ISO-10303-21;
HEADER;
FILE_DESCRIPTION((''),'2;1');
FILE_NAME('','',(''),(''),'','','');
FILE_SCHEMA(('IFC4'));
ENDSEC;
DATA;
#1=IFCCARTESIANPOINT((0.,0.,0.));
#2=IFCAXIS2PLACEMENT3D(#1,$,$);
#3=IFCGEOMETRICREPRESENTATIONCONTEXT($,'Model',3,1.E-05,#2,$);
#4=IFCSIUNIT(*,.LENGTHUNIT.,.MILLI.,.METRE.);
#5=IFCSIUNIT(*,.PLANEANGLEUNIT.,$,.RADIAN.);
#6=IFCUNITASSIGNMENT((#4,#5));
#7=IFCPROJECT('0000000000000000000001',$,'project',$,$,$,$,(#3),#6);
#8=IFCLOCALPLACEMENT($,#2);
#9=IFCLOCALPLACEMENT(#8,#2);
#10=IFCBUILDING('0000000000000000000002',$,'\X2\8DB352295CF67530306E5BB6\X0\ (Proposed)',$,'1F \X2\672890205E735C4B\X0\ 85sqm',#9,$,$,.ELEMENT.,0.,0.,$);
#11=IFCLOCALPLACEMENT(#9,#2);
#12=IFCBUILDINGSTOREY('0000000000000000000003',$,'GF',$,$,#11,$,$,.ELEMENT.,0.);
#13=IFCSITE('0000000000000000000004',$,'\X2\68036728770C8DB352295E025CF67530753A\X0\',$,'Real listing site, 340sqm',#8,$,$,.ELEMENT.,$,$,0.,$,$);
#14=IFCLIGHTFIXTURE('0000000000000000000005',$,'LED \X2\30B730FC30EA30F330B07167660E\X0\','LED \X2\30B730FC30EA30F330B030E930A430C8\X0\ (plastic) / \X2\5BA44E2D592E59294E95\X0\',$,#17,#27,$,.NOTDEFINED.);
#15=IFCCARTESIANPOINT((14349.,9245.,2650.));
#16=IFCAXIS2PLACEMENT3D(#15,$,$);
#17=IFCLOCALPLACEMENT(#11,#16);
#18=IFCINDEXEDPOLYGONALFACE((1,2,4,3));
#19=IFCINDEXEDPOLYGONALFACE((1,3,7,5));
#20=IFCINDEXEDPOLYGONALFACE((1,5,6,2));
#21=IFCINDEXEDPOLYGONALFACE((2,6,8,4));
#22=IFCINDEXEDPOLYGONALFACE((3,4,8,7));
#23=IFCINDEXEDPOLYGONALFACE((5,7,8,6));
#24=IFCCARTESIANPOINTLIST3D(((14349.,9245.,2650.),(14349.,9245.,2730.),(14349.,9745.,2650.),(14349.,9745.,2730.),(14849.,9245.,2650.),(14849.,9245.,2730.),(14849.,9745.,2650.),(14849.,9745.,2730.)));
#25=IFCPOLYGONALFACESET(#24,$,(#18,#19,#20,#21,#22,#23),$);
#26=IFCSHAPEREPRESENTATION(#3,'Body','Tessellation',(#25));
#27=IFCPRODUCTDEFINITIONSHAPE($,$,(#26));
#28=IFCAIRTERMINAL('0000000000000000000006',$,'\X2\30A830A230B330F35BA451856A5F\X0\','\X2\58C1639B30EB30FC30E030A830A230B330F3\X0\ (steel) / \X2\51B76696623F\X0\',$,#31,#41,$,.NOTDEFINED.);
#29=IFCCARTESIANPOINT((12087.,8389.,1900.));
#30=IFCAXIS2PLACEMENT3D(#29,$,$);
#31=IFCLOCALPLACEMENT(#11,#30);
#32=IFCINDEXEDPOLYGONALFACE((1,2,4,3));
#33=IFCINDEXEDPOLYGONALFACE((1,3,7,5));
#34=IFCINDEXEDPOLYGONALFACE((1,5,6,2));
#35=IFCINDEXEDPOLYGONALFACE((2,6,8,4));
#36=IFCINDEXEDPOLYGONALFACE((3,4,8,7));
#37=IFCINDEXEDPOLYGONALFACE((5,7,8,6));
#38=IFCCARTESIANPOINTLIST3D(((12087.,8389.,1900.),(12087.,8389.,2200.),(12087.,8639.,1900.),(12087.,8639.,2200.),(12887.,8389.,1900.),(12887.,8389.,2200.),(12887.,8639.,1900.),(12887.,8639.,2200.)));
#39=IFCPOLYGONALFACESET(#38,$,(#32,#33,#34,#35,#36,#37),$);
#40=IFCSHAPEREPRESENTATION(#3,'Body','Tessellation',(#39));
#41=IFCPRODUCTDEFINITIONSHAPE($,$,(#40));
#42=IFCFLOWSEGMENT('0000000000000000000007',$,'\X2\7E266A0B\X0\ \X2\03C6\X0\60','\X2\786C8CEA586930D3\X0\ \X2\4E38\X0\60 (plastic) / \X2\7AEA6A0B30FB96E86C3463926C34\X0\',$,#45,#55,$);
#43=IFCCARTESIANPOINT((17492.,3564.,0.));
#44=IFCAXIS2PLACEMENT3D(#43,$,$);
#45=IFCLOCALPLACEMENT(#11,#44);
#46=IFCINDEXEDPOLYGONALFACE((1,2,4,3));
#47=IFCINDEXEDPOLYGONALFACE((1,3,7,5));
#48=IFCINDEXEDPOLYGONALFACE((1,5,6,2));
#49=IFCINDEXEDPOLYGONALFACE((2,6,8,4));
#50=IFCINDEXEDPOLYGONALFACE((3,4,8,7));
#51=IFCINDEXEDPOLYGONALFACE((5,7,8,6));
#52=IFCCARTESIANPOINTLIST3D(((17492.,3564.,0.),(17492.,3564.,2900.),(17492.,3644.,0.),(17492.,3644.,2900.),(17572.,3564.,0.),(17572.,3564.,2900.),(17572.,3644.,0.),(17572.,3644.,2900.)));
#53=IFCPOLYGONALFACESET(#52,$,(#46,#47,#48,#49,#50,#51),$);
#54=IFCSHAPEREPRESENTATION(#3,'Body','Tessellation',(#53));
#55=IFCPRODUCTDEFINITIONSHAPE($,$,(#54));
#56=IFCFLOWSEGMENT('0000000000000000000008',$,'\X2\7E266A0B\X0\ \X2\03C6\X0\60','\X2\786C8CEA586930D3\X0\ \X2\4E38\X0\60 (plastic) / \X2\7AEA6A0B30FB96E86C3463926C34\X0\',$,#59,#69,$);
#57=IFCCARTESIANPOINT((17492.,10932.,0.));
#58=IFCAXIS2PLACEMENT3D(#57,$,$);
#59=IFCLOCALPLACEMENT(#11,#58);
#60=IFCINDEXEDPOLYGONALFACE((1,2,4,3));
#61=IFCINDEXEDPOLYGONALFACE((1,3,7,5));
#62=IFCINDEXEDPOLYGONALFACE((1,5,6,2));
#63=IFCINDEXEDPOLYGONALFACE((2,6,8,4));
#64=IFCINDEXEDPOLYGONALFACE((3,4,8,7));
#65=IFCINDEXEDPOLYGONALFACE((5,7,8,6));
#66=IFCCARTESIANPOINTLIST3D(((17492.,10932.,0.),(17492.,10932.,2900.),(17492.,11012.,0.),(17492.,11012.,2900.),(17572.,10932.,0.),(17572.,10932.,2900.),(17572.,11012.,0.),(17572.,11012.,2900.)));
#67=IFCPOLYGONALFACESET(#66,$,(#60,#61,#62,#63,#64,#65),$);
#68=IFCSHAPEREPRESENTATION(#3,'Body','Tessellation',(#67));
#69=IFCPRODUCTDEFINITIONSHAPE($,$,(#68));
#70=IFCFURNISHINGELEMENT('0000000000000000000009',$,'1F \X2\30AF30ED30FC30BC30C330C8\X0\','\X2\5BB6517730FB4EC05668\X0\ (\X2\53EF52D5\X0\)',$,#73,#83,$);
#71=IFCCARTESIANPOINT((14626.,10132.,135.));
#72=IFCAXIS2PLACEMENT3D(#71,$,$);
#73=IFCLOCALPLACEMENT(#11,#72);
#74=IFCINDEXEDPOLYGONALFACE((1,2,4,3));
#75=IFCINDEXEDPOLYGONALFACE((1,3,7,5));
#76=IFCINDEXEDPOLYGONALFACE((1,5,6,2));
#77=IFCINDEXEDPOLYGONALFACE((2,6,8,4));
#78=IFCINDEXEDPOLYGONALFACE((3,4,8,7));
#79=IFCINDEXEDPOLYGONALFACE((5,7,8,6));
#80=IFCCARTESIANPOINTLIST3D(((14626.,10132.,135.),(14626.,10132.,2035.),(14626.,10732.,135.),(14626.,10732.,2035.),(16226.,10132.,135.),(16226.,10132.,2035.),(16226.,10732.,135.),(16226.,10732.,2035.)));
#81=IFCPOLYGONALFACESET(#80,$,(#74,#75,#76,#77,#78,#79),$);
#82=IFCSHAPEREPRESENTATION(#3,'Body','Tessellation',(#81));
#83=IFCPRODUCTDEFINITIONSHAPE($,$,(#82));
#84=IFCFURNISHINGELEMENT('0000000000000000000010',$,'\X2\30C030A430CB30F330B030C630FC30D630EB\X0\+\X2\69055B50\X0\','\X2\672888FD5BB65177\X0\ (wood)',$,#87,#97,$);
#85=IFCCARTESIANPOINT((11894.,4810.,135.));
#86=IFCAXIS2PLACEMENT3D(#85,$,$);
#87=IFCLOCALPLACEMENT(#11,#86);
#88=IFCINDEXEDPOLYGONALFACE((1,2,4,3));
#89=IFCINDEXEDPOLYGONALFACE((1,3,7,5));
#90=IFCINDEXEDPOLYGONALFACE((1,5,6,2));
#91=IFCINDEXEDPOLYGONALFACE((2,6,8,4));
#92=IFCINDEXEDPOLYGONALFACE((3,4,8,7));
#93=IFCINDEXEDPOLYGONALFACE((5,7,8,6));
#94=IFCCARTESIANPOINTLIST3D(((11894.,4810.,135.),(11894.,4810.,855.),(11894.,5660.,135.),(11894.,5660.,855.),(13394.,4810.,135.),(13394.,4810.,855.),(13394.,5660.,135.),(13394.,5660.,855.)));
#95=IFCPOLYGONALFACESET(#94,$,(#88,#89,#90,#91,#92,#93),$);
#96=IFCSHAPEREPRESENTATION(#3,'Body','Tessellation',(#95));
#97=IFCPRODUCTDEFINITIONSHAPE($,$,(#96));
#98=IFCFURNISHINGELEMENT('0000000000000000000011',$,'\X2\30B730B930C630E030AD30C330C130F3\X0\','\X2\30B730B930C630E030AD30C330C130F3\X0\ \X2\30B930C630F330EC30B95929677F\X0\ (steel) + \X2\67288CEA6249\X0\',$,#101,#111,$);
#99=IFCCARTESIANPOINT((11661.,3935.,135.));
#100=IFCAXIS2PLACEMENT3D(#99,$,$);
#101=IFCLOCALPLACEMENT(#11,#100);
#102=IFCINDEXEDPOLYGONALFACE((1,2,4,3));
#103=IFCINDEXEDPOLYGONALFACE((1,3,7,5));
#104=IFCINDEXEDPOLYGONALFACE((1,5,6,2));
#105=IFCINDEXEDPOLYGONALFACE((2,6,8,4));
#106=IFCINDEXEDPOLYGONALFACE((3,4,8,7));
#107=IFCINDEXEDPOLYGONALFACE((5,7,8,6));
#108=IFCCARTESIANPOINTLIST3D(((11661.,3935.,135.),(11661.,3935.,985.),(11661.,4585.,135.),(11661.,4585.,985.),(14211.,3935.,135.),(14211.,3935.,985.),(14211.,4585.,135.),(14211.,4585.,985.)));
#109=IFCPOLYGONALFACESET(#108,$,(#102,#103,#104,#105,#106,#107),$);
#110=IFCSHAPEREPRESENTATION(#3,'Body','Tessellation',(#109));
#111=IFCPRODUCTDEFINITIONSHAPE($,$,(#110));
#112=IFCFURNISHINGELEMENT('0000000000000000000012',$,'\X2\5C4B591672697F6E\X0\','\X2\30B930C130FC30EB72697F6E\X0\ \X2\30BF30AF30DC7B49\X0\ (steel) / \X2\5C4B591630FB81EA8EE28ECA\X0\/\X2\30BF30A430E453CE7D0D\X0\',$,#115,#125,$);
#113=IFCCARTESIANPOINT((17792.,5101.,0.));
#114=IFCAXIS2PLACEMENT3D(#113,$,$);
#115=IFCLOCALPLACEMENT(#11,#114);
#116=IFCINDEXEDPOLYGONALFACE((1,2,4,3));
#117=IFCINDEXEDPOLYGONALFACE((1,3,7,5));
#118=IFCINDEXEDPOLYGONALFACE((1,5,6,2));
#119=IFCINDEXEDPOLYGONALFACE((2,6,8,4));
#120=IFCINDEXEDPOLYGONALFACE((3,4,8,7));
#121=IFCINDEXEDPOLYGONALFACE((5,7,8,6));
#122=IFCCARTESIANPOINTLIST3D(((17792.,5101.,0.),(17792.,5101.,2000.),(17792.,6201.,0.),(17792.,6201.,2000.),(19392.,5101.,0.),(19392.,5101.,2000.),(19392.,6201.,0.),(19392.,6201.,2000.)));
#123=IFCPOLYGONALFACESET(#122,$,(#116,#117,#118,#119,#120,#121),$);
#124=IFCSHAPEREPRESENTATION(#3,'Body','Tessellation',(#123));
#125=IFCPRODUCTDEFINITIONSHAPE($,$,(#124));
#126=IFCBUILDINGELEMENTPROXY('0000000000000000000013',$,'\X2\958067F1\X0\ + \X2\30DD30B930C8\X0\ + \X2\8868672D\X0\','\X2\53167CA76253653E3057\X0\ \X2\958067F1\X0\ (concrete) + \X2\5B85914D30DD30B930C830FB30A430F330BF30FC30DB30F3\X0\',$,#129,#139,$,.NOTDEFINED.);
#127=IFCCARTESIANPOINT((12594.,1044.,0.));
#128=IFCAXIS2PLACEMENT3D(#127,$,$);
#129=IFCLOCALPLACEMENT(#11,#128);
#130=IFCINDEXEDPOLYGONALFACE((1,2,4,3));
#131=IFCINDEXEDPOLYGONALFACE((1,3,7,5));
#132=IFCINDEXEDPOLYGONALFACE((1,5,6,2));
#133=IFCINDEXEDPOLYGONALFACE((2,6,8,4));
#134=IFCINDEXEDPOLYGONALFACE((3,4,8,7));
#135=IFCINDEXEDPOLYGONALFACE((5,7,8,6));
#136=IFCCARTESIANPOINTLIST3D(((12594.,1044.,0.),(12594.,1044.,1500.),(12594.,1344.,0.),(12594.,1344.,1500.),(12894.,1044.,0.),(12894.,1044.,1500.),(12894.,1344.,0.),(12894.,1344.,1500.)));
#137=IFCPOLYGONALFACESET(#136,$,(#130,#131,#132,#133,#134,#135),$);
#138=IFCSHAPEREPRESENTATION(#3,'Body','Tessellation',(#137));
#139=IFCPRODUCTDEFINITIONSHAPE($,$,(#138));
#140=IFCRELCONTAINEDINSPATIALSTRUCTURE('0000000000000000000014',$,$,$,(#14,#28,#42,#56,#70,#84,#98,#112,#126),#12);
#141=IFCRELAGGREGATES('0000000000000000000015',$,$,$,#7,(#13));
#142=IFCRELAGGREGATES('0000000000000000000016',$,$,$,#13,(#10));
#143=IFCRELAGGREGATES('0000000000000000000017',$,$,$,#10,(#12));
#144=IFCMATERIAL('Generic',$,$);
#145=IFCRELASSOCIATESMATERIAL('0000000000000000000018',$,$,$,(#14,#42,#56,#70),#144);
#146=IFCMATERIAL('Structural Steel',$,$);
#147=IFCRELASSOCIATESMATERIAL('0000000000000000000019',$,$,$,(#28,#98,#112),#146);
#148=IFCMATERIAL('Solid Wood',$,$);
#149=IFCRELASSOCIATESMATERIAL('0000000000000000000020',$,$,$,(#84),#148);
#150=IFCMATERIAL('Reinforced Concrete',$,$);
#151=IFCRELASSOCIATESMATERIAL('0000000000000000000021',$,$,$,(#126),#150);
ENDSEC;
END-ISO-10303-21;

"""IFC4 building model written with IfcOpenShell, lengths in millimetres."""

from ifc_helpers import new_model, si_unit, frame, frame_2d, origin, place, context, project, spatial, rectangle, extrude, material, element, save


model = new_model("IFC4")

# Units and contexts
model_context = context("Model", 3, precision=1e-05, world=origin())
ifc_project = project(units=[si_unit("LENGTHUNIT", "METRE", prefix="MILLI"), si_unit("PLANEANGLEUNIT", "RADIAN")], contexts=[model_context])

# Site, building, storey
site_placement = place(None, origin())
site = spatial("IfcSite", under=ifc_project, at=site_placement, Name="栃木県足利市島田町", ObjectType="Real listing site, 340sqm", CompositionType="ELEMENT", RefElevation=0.0)
building_placement = place(site_placement, origin())
building = spatial("IfcBuilding", under=site, at=building_placement, Name="足利島田の家 (Proposed)", ObjectType="1F 木造平屋 85sqm", CompositionType="ELEMENT", ElevationOfRefHeight=0.0, ElevationOfTerrain=0.0)
storey_placement = place(building_placement, origin())
storey = spatial("IfcBuildingStorey", under=building, at=storey_placement, Name="GF", CompositionType="ELEMENT", Elevation=0.0)

# Shared definitions
ifc_material_1 = material(Name="Solid Wood")

# Shared definitions
ifc_material_2 = material(Name="Reinforced Concrete")

# Shared definitions
ifc_material_3 = material(Name="Generic")

# Shared definitions
ifc_material_4 = material(Name="Structural Steel")

# Light fixture
light_fixture_1_placement = place(storey_placement, frame((14349.0, 9245.0, 2650.0)))
element("IfcLightFixture", 1, at=light_fixture_1_placement, inside=storey, material=ifc_material_3, Name="LED シーリング照明", Description="LED シーリングライト (plastic) / 室中央天井", PredefinedType="NOTDEFINED", context=model_context, shape_type="SweptSolid", body=[
    extrude(rectangle(XDim=500.0, YDim=500.0, at=frame_2d((250.0, 250.0))), frame((14349.0, 9245.0, 2650.0)), (0.0, 0.0, 1.0), 80.0),
])

# Air terminal
air_terminal_placement = place(storey_placement, frame((12087.0, 8389.0, 1900.0)))
element("IfcAirTerminal", 2, at=air_terminal_placement, inside=storey, material=ifc_material_4, Name="エアコン室内機", Description="壁掛ルームエアコン (steel) / 冷暖房", PredefinedType="NOTDEFINED", context=model_context, shape_type="SweptSolid", body=[
    extrude(rectangle(XDim=800.0, YDim=250.0, at=frame_2d((400.0, 125.0))), frame((12087.0, 8389.0, 1900.0)), (0.0, 0.0, 1.0), 300.0),
])

# Flow segments
flow_segment_1_placement = place(storey_placement, frame((17492.0, 3564.0, 0.0)))
element("IfcFlowSegment", 3, at=flow_segment_1_placement, inside=storey, material=ifc_material_3, Name="縦樋 φ60", Description="硬質塩ビ 丸60 (plastic) / 竪樋・雨水排水", context=model_context, shape_type="SweptSolid", body=[
    extrude(rectangle(XDim=80.0, YDim=80.0, at=frame_2d((40.0, 40.0))), frame((17492.0, 3564.0, 0.0)), (0.0, 0.0, 1.0), 2900.0),
])
flow_segment_2_placement = place(storey_placement, frame((17492.0, 10932.0, 0.0)))
element("IfcFlowSegment", 4, at=flow_segment_2_placement, inside=storey, material=ifc_material_3, Name="縦樋 φ60", Description="硬質塩ビ 丸60 (plastic) / 竪樋・雨水排水", context=model_context, shape_type="SweptSolid", body=[
    extrude(rectangle(XDim=80.0, YDim=80.0, at=frame_2d((40.0, 40.0))), frame((17492.0, 10932.0, 0.0)), (0.0, 0.0, 1.0), 2900.0),
])

# Furnishing elements
furnishing_1_placement = place(storey_placement, frame((14626.0, 10132.0, 135.0)))
element("IfcFurnishingElement", 5, at=furnishing_1_placement, inside=storey, material=ifc_material_3, Name="1F クローゼット", Description="家具・什器 (可動)", context=model_context, shape_type="SweptSolid", body=[
    extrude(rectangle(XDim=1600.0, YDim=600.0, at=frame_2d((800.0, 300.0))), frame((14626.0, 10132.0, 135.0)), (0.0, 0.0, 1.0), 1900.0),
])
furnishing_2_placement = place(storey_placement, frame((11894.0, 4810.0, 135.0)))
element("IfcFurnishingElement", 6, at=furnishing_2_placement, inside=storey, material=ifc_material_1, Name="ダイニングテーブル+椅子", Description="木製家具 (wood)", context=model_context, shape_type="SweptSolid", body=[
    extrude(rectangle(XDim=1500.0, YDim=850.0, at=frame_2d((750.0, 425.0))), frame((11894.0, 4810.0, 135.0)), (0.0, 0.0, 1.0), 720.0),
])
furnishing_3_placement = place(storey_placement, frame((11661.0, 3935.0, 135.0)))
element("IfcFurnishingElement", 7, at=furnishing_3_placement, inside=storey, material=ifc_material_4, Name="システムキッチン", Description="システムキッチン ステンレス天板 (steel) + 木質扉", context=model_context, shape_type="SweptSolid", body=[
    extrude(rectangle(XDim=2550.0, YDim=650.0, at=frame_2d((1275.0, 325.0))), frame((11661.0, 3935.0, 135.0)), (0.0, 0.0, 1.0), 850.0),
])
furnishing_4_placement = place(storey_placement, frame((17792.0, 5101.0, 0.0)))
element("IfcFurnishingElement", 8, at=furnishing_4_placement, inside=storey, material=ifc_material_4, Name="屋外物置", Description="スチール物置 タクボ等 (steel) / 屋外・自転車/タイヤ収納", context=model_context, shape_type="SweptSolid", body=[
    extrude(rectangle(XDim=1600.0, YDim=1100.0, at=frame_2d((800.0, 550.0))), frame((17792.0, 5101.0, 0.0)), (0.0, 0.0, 1.0), 2000.0),
])

# Building element proxy
proxy_placement = place(storey_placement, frame((12594.0, 1044.0, 0.0)))
element("IfcBuildingElementProxy", 9, at=proxy_placement, inside=storey, material=ifc_material_2, Name="門柱 + ポスト + 表札", Description="化粧打放し 門柱 (concrete) + 宅配ポスト・インターホン", PredefinedType="NOTDEFINED", context=model_context, shape_type="SweptSolid", body=[
    extrude(rectangle(XDim=300.0, YDim=300.0, at=frame_2d((150.0, 150.0))), frame((12594.0, 1044.0, 0.0)), (0.0, 0.0, 1.0), 1500.0),
])

save(model, "model.ifc")
